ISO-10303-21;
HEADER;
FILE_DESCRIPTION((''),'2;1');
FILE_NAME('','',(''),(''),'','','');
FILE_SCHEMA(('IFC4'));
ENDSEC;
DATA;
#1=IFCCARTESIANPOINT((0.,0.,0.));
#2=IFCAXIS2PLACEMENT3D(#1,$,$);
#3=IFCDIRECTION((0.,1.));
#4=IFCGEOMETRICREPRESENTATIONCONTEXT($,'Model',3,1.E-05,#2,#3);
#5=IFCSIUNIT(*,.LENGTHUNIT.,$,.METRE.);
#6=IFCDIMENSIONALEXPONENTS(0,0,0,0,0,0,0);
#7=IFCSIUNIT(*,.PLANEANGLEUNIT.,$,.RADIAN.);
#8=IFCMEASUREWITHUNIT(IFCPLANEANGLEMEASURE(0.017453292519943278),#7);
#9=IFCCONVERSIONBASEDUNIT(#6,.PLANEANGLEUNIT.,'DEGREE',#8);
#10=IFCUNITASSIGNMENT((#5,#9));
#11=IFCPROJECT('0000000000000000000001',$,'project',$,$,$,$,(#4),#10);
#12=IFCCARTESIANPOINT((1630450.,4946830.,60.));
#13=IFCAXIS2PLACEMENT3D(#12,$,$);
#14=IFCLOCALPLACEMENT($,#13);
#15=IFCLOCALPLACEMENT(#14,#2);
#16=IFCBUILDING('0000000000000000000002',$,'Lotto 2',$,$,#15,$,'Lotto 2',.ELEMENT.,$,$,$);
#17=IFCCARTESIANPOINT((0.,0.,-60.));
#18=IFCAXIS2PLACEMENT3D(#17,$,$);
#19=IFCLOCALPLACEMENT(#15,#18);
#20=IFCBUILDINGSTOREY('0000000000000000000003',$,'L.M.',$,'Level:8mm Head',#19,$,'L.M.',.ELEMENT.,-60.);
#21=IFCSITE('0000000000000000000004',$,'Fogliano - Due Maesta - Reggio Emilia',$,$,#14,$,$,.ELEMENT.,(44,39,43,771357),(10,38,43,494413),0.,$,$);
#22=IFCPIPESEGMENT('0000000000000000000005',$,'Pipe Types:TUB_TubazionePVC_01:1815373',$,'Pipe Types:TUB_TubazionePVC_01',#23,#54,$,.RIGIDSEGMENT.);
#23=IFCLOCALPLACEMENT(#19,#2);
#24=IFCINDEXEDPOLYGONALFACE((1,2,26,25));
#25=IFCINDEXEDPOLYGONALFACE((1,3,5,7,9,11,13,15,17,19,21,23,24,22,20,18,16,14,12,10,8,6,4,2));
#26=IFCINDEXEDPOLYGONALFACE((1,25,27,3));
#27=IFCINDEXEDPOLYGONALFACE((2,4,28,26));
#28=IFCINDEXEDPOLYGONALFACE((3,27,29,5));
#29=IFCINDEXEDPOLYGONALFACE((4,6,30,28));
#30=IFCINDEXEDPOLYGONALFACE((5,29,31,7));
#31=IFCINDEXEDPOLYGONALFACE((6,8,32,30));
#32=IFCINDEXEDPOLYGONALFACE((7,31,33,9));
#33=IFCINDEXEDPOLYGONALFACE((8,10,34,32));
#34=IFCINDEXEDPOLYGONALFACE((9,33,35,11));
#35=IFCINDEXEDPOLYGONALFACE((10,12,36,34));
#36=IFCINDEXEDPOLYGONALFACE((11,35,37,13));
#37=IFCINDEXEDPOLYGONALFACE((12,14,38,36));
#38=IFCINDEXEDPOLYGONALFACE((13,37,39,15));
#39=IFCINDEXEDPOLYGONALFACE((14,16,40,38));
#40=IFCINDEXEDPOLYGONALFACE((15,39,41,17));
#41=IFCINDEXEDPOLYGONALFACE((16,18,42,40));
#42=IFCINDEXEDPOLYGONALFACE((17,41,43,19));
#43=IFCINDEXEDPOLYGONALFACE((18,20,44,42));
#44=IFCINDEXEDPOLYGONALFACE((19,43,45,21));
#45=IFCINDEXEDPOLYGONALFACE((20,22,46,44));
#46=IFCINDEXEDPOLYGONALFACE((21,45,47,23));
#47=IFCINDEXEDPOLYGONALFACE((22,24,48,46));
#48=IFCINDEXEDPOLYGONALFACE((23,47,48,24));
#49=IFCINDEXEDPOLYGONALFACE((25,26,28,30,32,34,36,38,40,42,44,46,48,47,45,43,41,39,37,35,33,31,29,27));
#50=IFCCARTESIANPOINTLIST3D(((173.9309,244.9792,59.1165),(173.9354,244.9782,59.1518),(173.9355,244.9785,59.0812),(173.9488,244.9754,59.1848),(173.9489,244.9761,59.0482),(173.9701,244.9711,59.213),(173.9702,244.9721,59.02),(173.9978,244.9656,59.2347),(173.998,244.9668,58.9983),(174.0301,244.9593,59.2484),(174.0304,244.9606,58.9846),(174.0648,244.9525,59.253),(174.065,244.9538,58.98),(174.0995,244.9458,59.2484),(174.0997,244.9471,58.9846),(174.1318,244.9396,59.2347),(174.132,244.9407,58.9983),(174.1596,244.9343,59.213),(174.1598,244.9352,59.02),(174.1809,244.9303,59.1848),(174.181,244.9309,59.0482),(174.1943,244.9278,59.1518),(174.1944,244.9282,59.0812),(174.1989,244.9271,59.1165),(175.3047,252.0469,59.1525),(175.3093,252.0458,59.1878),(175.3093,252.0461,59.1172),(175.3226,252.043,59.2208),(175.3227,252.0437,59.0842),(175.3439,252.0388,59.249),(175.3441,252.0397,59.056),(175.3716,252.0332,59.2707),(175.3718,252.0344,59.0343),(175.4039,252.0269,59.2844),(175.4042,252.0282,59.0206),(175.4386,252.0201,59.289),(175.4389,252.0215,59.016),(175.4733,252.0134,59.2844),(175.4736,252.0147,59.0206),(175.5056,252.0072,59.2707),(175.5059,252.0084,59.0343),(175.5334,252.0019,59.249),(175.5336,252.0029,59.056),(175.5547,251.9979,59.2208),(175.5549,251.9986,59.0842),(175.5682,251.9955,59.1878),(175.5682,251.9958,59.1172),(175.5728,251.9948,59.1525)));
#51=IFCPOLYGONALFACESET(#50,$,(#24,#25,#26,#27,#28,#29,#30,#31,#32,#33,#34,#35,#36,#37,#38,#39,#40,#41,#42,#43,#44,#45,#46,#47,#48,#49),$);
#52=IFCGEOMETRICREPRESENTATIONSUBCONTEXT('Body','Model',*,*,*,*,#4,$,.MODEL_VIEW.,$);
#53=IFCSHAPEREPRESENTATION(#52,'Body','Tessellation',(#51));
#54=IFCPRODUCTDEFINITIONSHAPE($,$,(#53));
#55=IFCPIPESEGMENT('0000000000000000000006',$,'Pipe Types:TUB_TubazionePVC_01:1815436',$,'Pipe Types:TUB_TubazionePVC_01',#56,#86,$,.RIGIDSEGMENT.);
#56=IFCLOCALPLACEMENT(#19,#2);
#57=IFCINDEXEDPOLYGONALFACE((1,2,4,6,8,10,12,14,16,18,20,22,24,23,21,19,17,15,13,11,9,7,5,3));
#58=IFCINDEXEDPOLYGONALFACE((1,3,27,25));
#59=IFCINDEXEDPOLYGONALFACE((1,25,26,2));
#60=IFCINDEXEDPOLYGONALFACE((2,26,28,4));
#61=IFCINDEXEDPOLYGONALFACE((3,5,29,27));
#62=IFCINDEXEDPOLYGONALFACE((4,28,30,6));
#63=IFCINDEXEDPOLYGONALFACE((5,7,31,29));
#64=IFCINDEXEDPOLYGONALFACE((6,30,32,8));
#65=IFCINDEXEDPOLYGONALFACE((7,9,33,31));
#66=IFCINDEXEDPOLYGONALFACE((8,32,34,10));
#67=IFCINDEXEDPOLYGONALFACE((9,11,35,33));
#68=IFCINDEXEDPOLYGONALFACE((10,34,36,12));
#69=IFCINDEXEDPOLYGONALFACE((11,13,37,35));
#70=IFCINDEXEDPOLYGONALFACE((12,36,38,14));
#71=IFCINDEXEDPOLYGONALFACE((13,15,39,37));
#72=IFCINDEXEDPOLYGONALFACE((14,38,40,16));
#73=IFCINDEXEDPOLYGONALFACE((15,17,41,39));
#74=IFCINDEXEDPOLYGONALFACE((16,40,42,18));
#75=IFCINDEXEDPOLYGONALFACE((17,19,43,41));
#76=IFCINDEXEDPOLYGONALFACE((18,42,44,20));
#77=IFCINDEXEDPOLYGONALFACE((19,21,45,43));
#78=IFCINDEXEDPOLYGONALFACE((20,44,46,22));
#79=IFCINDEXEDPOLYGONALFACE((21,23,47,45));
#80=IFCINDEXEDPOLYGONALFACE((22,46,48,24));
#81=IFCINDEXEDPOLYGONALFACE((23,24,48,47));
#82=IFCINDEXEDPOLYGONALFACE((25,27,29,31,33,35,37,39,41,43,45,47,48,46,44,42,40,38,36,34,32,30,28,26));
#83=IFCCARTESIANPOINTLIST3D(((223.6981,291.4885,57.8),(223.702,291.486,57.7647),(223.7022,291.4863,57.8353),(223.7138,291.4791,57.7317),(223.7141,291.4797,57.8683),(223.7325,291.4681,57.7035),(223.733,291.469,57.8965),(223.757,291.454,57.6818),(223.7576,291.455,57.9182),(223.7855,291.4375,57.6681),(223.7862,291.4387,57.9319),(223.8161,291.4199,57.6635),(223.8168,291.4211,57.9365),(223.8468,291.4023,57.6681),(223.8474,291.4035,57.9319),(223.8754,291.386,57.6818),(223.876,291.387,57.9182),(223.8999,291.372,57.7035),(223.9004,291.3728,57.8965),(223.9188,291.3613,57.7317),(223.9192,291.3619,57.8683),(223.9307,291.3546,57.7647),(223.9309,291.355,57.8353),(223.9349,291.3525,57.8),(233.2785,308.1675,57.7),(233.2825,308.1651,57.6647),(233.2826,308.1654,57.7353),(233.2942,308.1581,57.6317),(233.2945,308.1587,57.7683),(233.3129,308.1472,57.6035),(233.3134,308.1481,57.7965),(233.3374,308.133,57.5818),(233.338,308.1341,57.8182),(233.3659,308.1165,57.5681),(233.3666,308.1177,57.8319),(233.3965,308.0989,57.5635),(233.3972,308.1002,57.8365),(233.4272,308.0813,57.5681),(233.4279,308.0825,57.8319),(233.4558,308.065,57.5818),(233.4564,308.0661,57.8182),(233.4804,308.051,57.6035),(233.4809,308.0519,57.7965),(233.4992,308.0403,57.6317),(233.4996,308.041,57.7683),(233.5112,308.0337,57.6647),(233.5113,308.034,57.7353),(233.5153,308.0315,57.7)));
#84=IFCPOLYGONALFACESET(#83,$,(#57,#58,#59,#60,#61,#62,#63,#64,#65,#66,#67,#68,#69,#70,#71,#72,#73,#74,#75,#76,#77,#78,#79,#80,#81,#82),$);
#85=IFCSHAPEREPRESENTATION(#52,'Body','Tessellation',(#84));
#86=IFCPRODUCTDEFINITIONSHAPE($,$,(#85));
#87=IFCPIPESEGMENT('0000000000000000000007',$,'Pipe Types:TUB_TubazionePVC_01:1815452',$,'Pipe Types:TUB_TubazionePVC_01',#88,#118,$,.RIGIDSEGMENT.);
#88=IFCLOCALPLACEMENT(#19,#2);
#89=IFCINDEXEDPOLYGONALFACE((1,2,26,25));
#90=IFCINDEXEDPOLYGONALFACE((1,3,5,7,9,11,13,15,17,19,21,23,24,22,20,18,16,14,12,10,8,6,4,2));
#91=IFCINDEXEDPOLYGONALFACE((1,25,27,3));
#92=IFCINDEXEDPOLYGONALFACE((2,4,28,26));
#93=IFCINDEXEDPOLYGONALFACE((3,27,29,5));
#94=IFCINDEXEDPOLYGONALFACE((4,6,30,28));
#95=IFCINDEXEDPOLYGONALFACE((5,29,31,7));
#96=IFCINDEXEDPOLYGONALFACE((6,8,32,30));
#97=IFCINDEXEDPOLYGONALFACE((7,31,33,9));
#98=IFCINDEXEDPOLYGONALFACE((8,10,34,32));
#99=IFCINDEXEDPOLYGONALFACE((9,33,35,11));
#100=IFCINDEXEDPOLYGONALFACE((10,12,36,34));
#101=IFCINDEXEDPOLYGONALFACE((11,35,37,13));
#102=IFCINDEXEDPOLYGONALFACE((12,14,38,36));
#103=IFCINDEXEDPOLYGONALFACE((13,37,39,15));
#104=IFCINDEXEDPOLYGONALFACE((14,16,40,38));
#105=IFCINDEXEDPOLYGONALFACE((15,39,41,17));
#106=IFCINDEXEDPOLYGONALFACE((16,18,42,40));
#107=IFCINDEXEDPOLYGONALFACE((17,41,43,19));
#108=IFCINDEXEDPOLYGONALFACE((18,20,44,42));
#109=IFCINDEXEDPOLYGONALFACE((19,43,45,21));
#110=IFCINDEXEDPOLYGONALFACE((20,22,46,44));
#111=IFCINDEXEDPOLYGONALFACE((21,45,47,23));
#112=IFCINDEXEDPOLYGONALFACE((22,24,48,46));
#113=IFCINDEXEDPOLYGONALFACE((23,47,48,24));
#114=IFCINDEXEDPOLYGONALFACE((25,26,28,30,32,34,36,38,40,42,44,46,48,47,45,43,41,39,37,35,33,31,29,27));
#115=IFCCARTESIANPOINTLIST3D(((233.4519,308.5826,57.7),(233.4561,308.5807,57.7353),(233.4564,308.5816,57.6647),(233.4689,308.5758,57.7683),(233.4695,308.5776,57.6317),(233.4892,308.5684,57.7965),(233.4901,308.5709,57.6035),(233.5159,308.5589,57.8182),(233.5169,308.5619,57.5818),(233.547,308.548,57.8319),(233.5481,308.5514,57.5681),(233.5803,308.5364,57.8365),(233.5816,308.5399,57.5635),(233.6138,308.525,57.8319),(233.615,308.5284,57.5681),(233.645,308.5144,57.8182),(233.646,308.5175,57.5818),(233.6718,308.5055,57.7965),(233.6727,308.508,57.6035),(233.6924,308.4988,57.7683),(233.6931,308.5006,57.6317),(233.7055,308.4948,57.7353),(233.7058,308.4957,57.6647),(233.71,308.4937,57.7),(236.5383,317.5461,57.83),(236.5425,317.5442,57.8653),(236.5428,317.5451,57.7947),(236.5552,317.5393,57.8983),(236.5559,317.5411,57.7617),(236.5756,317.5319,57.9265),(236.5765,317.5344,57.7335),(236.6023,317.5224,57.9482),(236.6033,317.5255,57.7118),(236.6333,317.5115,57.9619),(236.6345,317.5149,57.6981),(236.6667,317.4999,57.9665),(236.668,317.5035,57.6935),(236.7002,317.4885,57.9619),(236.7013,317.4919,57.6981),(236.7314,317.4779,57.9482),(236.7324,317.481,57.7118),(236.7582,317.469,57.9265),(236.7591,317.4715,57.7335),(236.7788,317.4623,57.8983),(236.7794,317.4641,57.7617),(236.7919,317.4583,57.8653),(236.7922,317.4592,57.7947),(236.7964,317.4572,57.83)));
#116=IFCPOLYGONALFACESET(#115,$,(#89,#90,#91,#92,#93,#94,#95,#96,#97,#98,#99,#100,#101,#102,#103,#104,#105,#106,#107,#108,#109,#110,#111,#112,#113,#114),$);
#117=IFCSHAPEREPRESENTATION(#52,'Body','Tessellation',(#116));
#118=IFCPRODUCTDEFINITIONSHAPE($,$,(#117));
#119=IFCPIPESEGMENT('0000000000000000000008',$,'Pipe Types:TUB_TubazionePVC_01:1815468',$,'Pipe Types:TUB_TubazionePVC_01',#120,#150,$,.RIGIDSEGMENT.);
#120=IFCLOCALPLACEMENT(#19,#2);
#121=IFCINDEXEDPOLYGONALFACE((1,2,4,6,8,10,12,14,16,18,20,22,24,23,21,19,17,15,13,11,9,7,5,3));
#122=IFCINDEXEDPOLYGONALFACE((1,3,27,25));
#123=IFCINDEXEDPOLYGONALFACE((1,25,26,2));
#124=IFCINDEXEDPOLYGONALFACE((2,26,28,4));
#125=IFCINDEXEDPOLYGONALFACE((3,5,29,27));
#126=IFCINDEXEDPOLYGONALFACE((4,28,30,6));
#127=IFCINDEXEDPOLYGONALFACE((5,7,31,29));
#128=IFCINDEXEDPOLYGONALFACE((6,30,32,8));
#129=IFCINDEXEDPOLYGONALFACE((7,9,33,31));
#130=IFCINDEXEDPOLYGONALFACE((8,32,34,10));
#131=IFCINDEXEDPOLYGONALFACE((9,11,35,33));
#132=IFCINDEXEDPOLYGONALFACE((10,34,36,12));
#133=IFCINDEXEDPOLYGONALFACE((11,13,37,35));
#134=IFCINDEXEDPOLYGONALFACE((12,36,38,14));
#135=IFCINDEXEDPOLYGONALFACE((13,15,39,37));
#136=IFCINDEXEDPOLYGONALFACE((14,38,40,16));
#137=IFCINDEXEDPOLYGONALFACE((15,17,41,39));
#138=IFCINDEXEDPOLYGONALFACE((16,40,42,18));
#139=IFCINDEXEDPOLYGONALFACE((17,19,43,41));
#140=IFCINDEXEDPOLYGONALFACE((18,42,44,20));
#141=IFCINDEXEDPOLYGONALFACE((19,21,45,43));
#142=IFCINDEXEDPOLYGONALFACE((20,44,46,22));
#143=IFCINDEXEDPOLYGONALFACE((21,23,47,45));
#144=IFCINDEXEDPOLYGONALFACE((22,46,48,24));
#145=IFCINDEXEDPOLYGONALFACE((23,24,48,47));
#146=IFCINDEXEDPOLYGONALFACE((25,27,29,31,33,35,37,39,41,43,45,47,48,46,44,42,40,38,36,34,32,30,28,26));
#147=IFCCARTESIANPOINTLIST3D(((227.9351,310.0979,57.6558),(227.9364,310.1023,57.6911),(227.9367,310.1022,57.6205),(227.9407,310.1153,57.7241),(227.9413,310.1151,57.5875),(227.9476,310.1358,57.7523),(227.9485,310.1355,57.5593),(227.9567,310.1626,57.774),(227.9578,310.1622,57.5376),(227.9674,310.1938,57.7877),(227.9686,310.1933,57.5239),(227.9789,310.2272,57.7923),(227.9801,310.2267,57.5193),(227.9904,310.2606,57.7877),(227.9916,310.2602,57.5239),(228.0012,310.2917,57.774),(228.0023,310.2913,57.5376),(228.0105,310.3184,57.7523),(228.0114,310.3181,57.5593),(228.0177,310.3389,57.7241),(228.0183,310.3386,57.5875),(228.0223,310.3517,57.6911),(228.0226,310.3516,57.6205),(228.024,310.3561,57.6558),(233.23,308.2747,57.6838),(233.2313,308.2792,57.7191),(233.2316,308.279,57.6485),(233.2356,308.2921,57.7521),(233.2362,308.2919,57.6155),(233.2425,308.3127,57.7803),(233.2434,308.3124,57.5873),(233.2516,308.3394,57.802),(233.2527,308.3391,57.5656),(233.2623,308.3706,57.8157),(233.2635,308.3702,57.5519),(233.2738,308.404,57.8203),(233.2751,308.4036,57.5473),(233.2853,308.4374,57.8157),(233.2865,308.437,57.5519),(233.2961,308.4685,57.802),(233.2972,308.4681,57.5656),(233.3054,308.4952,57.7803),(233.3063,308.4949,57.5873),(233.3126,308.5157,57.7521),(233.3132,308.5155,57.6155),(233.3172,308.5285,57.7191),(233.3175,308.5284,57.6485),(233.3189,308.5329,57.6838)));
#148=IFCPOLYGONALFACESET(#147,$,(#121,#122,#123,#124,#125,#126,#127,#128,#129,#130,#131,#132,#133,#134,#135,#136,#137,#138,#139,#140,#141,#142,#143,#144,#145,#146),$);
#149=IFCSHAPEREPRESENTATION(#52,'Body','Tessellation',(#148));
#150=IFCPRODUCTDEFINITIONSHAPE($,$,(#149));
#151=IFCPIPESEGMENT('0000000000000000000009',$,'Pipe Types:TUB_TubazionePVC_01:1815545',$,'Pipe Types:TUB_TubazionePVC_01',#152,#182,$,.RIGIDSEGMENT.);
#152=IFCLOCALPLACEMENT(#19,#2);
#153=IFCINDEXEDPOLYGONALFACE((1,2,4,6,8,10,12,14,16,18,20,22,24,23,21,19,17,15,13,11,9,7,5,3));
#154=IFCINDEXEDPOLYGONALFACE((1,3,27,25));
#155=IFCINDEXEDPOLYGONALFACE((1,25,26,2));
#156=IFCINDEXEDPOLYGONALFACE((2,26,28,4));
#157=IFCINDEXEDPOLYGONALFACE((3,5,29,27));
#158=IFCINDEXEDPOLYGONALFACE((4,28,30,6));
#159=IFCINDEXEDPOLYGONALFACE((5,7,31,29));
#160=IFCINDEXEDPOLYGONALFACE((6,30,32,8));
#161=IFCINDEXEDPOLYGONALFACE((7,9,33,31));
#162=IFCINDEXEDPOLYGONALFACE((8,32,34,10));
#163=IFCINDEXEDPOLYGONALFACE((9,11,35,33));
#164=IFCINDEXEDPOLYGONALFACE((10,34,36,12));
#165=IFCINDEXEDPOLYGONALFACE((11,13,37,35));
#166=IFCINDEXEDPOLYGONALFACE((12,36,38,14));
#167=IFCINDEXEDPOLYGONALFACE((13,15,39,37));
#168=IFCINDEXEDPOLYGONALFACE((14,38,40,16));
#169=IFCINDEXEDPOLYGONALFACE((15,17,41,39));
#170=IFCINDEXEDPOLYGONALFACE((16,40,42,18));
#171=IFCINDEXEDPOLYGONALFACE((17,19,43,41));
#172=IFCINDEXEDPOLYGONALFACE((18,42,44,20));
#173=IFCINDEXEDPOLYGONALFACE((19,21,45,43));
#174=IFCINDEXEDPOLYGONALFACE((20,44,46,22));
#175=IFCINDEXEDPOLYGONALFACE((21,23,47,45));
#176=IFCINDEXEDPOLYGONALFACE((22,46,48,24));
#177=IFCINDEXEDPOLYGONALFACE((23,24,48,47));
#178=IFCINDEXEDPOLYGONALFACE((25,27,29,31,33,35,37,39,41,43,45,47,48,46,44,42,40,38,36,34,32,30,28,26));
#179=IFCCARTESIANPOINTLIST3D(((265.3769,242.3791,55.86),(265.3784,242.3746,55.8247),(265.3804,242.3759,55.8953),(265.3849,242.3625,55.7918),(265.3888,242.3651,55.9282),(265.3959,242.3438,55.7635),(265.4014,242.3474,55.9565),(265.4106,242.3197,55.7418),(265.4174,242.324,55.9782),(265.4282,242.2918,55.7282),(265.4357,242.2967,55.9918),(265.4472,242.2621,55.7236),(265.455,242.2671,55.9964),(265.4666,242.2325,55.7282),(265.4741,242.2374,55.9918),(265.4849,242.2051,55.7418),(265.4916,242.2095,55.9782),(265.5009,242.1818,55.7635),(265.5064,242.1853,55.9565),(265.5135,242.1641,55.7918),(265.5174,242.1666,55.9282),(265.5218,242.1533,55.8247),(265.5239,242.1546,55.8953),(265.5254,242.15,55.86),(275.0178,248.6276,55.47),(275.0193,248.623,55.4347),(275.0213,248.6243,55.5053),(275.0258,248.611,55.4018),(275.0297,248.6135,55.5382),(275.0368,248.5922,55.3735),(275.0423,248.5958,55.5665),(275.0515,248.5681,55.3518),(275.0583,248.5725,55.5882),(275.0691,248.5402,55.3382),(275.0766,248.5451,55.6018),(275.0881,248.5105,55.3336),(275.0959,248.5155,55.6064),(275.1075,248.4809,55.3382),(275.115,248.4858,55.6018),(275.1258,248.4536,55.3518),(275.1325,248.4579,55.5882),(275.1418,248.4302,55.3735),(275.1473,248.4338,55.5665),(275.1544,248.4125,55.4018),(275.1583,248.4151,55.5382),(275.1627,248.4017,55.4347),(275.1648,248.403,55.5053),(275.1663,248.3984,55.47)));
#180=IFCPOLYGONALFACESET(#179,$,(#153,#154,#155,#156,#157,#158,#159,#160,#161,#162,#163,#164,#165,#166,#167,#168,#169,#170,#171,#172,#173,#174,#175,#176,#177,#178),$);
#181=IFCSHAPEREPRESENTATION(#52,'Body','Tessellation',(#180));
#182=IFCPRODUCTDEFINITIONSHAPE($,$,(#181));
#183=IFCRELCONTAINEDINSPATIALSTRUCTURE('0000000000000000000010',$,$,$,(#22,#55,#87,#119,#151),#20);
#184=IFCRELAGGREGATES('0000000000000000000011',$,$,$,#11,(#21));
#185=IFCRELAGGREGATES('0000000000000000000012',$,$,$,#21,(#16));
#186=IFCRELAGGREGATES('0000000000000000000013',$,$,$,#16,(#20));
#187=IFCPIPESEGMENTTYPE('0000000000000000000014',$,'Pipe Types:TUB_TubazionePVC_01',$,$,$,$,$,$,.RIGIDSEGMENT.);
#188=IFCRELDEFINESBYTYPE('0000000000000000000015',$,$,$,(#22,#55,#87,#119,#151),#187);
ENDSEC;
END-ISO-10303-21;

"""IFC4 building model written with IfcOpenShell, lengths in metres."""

from ifc_helpers import new_model, entity, si_unit, converted_unit, direction, frame, origin, place, context, subcontext, project, spatial, arc, indexed_curve, outline, extrude, type_object, element, save


model = new_model("IFC4")

# Units and contexts
model_context = context("Model", 3, precision=1e-05, world=origin(), true_north=direction((0.0, 1.0)))
body_context = subcontext(model_context, "Body", "Model", "MODEL_VIEW")
ifc_project = project(units=[si_unit("LENGTHUNIT", "METRE"), converted_unit("PLANEANGLEUNIT", "DEGREE", entity("IfcPlaneAngleMeasure", 0.017453292519943278), si_unit("PLANEANGLEUNIT", "RADIAN"), dimensions=[0, 0, 0, 0, 0, 0, 0])], contexts=[model_context])

# Site, building, storey
site_placement = place(None, frame((1630450.0, 4946830.0, 60.0)))
site = spatial("IfcSite", under=ifc_project, at=site_placement, Name="Fogliano - Due Maesta - Reggio Emilia", CompositionType="ELEMENT", RefLatitude=(44, 39, 43, 771357), RefLongitude=(10, 38, 43, 494413), RefElevation=0.0)
building_placement = place(site_placement, origin())
building = spatial("IfcBuilding", under=site, at=building_placement, Name="Lotto 2", LongName="Lotto 2", CompositionType="ELEMENT")
storey_placement = place(building_placement, frame((0.0, 0.0, -60.0)))
storey = spatial("IfcBuildingStorey", under=building, at=storey_placement, Name="L.M.", ObjectType="Level:8mm Head", LongName="L.M.", CompositionType="ELEMENT", Elevation=-60.0)

# Pipe segments
pipe_segment_type = type_object("IfcPipeSegmentType", Name="Pipe Types:TUB_TubazionePVC_01", PredefinedType="RIGIDSEGMENT")
pipe_segment_1_placement = place(storey_placement, origin())
element("IfcPipeSegment", 1, at=pipe_segment_1_placement, inside=storey, type_object=pipe_segment_type, Name="Pipe Types:TUB_TubazionePVC_01:1815373", ObjectType="Pipe Types:TUB_TubazionePVC_01", PredefinedType="RIGIDSEGMENT", context=body_context, shape_type="SweptSolid", body=[
    extrude(outline(indexed_curve([(0.1365, 0.0), (0.0965, 0.0965), (0.0, 0.1365), (-0.0965, 0.0965), (-0.1365, 0.0), (-0.0965, -0.0965), (0.0, -0.1365), (0.0965, -0.0965)], segments=[arc(1, 2, 3), arc(3, 4, 5), arc(5, 6, 7), arc(7, 8, 1)], self_intersect=False)), frame((174.0649, 244.9532, 59.1165), z_axis=(0.190809, 0.981614, 0.005), x_axis=(-0.981627, 0.190811, 0.0)), (0.0, 0.0, 1.0), 7.2),
])
pipe_segment_2_placement = place(storey_placement, origin())
element("IfcPipeSegment", 2, at=pipe_segment_2_placement, inside=storey, type_object=pipe_segment_type, Name="Pipe Types:TUB_TubazionePVC_01:1815436", ObjectType="Pipe Types:TUB_TubazionePVC_01", PredefinedType="RIGIDSEGMENT", context=body_context, shape_type="SweptSolid", body=[
    extrude(outline(indexed_curve([(0.1365, 0.0), (0.0965, 0.0965), (0.0, 0.1365), (-0.0965, 0.0965), (-0.1365, 0.0), (-0.0965, -0.0965), (0.0, -0.1365), (0.0965, -0.0965)], segments=[arc(1, 2, 3), arc(3, 4, 5), arc(5, 6, 7), arc(7, 8, 1)], self_intersect=False)), frame((223.8165, 291.4205, 57.8), z_axis=(0.498073, 0.86712, -0.005199), x_axis=(0.867131, -0.49808, 0.0)), (0.0, 0.0, 1.0), 19.235),
])
pipe_segment_3_placement = place(storey_placement, origin())
element("IfcPipeSegment", 3, at=pipe_segment_3_placement, inside=storey, type_object=pipe_segment_type, Name="Pipe Types:TUB_TubazionePVC_01:1815452", ObjectType="Pipe Types:TUB_TubazionePVC_01", PredefinedType="RIGIDSEGMENT", context=body_context, shape_type="SweptSolid", body=[
    extrude(outline(indexed_curve([(0.1365, 0.0), (0.0965, 0.0965), (0.0, 0.1365), (-0.0965, 0.0965), (-0.1365, 0.0), (-0.0965, -0.0965), (0.0, -0.1365), (0.0965, -0.0965)], segments=[arc(1, 2, 3), arc(3, 4, 5), arc(5, 6, 7), arc(7, 8, 1)], self_intersect=False)), frame((233.581, 308.5382, 57.7), z_axis=(0.325538, 0.94543, 0.013712), x_axis=(0.945519, -0.325568, 0.0)), (0.0, 0.0, 1.0), 9.4809),
])
pipe_segment_4_placement = place(storey_placement, origin())
element("IfcPipeSegment", 4, at=pipe_segment_4_placement, inside=storey, type_object=pipe_segment_type, Name="Pipe Types:TUB_TubazionePVC_01:1815468", ObjectType="Pipe Types:TUB_TubazionePVC_01", PredefinedType="RIGIDSEGMENT", context=body_context, shape_type="SweptSolid", body=[
    extrude(outline(indexed_curve([(0.1365, 0.0), (0.0965, 0.0965), (0.0, 0.1365), (-0.0965, 0.0965), (-0.1365, 0.0), (-0.0965, -0.0965), (0.0, -0.1365), (0.0965, -0.0965)], segments=[arc(1, 2, 3), arc(3, 4, 5), arc(5, 6, 7), arc(7, 8, 1)], self_intersect=False)), frame((227.9795, 310.227, 57.6558), z_axis=(0.945507, -0.325564, 0.005), x_axis=(0.325568, 0.945519, 0.0)), (0.0, 0.0, 1.0), 5.6001),
])
pipe_segment_5_placement = place(storey_placement, origin())
element("IfcPipeSegment", 5, at=pipe_segment_5_placement, inside=storey, type_object=pipe_segment_type, Name="Pipe Types:TUB_TubazionePVC_01:1815545", ObjectType="Pipe Types:TUB_TubazionePVC_01", PredefinedType="RIGIDSEGMENT", context=body_context, shape_type="SweptSolid", body=[
    extrude(outline(indexed_curve([(0.1365, 0.0), (0.0965, 0.0965), (0.0, 0.1365), (-0.0965, 0.0965), (-0.1365, 0.0), (-0.0965, -0.0965), (0.0, -0.1365), (0.0965, -0.0965)], segments=[arc(1, 2, 3), arc(3, 4, 5), arc(5, 6, 7), arc(7, 8, 1)], self_intersect=False)), frame((275.092, 248.513, 55.47), z_axis=(-0.838682, -0.543564, 0.033927), x_axis=(0.543877, -0.839165, 0.0)), (0.0, 0.0, 1.0), 11.4953),
])

save(model, "model.ifc")
